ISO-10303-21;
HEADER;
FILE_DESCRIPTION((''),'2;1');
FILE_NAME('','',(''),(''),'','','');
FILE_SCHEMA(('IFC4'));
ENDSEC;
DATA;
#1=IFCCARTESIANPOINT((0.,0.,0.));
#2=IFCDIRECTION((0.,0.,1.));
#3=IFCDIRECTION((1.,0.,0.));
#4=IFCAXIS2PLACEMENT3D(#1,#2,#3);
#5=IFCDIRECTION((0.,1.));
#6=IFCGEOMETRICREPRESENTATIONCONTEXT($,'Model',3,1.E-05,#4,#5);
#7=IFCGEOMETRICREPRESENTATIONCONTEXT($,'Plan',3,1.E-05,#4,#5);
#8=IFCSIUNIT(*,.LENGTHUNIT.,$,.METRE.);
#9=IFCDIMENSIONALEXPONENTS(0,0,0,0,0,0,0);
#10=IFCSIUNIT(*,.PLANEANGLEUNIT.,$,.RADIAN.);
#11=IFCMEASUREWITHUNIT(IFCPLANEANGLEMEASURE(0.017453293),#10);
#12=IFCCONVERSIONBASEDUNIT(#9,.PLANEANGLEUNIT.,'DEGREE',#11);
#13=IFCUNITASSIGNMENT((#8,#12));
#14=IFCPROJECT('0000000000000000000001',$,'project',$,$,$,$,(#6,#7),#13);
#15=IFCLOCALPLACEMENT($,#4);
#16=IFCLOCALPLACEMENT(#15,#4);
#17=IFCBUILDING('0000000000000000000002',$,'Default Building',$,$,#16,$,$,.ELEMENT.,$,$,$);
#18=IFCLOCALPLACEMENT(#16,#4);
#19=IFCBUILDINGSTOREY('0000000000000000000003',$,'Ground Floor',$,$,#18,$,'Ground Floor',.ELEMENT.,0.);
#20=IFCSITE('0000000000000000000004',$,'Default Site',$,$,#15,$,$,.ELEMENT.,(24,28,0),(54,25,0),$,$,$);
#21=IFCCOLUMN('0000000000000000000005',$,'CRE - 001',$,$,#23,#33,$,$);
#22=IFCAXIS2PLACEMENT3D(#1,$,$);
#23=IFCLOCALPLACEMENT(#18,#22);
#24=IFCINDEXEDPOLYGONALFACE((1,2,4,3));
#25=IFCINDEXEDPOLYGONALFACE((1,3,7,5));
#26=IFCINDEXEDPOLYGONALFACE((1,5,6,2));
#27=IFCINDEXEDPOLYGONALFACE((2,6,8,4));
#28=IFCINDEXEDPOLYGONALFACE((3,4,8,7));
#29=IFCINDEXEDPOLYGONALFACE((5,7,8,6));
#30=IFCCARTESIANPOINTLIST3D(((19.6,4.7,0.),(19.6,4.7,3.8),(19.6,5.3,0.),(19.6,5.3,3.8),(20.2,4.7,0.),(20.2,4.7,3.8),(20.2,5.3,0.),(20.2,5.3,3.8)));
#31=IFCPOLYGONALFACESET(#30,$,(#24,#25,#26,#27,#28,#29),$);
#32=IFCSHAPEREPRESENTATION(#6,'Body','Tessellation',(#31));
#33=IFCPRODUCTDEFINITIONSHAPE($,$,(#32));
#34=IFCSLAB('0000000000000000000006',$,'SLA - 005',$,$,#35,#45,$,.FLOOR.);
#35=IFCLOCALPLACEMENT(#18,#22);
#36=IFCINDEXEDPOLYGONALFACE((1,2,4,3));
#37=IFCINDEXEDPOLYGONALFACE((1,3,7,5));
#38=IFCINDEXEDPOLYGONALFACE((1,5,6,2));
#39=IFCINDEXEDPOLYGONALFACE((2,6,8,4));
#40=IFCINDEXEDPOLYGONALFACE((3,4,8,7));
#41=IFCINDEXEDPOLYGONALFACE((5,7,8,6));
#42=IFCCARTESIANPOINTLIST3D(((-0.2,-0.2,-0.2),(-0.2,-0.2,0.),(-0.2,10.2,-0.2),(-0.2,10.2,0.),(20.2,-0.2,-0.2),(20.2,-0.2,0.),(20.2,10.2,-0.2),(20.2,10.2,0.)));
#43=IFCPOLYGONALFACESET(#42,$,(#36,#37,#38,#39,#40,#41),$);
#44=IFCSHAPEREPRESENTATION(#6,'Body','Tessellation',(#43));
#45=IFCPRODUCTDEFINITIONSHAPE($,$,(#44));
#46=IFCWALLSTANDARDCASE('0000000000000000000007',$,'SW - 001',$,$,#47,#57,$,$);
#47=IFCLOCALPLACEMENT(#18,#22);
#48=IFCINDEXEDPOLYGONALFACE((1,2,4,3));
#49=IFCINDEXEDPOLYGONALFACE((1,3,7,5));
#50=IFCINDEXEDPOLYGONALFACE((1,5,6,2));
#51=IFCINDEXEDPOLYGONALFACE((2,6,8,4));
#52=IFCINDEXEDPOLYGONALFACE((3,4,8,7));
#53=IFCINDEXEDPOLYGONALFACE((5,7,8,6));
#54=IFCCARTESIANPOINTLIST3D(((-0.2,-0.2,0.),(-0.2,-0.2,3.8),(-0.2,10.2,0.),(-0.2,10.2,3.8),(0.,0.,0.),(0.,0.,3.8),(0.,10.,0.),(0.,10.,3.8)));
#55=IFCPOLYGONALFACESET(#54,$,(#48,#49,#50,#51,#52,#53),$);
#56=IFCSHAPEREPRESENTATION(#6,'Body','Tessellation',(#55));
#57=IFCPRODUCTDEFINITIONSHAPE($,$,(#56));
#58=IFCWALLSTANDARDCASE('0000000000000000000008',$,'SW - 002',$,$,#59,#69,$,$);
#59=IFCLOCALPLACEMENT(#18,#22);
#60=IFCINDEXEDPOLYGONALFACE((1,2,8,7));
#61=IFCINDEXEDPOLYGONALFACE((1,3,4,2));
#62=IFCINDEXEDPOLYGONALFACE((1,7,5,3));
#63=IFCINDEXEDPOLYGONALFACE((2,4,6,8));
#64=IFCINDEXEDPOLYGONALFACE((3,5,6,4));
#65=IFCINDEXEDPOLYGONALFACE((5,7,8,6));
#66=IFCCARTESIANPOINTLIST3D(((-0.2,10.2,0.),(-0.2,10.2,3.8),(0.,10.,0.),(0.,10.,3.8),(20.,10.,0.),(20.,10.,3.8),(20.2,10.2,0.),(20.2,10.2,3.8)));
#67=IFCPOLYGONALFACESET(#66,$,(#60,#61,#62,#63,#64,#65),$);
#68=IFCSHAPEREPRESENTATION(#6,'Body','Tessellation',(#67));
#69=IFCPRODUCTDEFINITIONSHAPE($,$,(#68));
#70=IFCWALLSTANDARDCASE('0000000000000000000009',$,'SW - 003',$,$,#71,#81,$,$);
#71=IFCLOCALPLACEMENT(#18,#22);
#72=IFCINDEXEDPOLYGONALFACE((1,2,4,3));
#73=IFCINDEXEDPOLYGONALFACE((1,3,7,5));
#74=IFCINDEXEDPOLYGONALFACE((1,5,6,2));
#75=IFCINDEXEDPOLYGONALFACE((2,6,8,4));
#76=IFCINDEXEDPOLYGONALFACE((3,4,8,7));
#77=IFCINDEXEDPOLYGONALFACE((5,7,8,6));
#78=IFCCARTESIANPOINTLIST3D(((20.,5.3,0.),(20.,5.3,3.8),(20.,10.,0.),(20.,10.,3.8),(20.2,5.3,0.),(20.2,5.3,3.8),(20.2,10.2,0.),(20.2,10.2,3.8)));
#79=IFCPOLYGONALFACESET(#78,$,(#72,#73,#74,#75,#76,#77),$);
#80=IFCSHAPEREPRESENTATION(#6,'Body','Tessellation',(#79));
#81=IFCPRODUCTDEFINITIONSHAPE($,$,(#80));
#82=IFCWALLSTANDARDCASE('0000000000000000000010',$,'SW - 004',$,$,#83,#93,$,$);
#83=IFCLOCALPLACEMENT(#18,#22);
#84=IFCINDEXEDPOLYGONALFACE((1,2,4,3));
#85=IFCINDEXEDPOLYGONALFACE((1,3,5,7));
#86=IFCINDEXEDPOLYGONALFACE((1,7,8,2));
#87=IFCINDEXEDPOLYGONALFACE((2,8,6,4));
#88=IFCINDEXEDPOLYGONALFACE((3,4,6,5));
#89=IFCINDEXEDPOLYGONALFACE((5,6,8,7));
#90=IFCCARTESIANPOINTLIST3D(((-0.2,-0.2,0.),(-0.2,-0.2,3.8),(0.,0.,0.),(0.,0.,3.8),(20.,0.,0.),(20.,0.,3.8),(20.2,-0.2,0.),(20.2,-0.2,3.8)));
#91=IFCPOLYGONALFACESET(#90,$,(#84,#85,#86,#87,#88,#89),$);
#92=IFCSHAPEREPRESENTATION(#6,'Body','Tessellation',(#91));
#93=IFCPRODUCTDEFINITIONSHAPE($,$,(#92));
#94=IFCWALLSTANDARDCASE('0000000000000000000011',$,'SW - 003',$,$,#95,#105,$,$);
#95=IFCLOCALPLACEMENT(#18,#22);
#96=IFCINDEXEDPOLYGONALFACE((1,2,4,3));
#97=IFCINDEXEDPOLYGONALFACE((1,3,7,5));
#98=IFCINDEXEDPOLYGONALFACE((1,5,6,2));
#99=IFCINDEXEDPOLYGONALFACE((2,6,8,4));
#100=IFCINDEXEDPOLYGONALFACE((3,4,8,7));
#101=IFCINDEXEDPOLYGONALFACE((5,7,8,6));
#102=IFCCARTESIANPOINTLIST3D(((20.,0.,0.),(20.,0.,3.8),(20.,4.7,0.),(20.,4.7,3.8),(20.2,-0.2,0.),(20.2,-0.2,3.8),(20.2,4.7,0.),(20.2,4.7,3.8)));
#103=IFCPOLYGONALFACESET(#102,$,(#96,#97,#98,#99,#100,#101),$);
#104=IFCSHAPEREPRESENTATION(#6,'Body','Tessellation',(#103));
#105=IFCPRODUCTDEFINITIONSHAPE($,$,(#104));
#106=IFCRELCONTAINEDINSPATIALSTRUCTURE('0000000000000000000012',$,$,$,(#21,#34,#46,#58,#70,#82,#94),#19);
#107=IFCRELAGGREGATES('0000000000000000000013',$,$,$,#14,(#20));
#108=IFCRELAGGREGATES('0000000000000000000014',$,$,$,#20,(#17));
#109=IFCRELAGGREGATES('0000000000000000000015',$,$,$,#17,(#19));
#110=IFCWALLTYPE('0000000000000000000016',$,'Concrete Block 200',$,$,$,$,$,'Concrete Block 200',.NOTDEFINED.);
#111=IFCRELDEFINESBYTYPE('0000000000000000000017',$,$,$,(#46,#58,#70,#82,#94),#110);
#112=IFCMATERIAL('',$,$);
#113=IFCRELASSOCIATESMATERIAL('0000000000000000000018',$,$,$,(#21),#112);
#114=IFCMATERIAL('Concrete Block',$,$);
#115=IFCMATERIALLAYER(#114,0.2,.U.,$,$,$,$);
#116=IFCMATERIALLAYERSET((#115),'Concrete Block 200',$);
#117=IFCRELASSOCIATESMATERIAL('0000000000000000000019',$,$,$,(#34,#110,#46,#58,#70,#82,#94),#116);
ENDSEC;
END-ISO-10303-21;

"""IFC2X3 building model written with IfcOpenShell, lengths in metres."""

from ifc_helpers import new_model, entity, si_unit, converted_unit, direction, frame, origin_with_axes, origin_2d_with_axis, place, context, project, spatial, polyline, rectangle, outline, extrude, material, layer, layer_set, layer_usage, type_object, element, save


model = new_model("IFC2X3")

# Units and contexts
model_context = context("Model", 3, precision=1e-05, world=origin_with_axes(), true_north=direction((0.0, 1.0)))
plan_context = context("Plan", 3, precision=1e-05, world=origin_with_axes(), true_north=direction((0.0, 1.0)))
ifc_project = project(units=[si_unit("LENGTHUNIT", "METRE"), converted_unit("PLANEANGLEUNIT", "DEGREE", entity("IfcPlaneAngleMeasure", 0.017453293), si_unit("PLANEANGLEUNIT", "RADIAN"), dimensions=[0, 0, 0, 0, 0, 0, 0])], contexts=[model_context, plan_context])

# Site, building, storey
site_placement = place(None, origin_with_axes())
site = spatial("IfcSite", under=ifc_project, at=site_placement, Name="Default Site", CompositionType="ELEMENT", RefLatitude=(24, 28, 0), RefLongitude=(54, 25, 0))
building_placement = place(site_placement, origin_with_axes())
building = spatial("IfcBuilding", under=site, at=building_placement, Name="Default Building", CompositionType="ELEMENT")
storey_placement = place(building_placement, origin_with_axes())
storey = spatial("IfcBuildingStorey", under=building, at=storey_placement, Name="Ground Floor", LongName="Ground Floor", CompositionType="ELEMENT", Elevation=0.0)

# Column
ifc_material_1 = material(Name="")
column_placement = place(storey_placement, frame((19.9, 5.0, 0.0), z_axis=(0.0, 0.0, 1.0), x_axis=(1.0, 0.0, 0.0)))
element("IfcColumn", 1, at=column_placement, inside=storey, material=ifc_material_1, Name="CRE - 001", context=model_context, shape_type="SweptSolid", body=[
    extrude(rectangle(XDim=0.6, YDim=0.6, at=origin_2d_with_axis()), origin_with_axes(), (0.0, 0.0, 1.0), 3.8),
])

# Slab
ifc_material_2 = material(Name="Concrete Block")
ifc_layer = layer(ifc_material_2, 0.2, ventilated="UNKNOWN")
ifc_layer_set = layer_set([ifc_layer], Name="Concrete Block 200")
ifc_layer_usage_1 = layer_usage(ifc_layer_set, "AXIS3", "NEGATIVE", 0.2)
slab_placement = place(storey_placement, frame((-0.2, 10.2, -0.2), z_axis=(0.0, 0.0, 1.0), x_axis=(1.0, 0.0, 0.0)))
element("IfcSlab", 2, at=slab_placement, inside=storey, material=ifc_layer_usage_1, Name="SLA - 005", PredefinedType="FLOOR", context=model_context, shape_type="SweptSolid", body=[
    extrude(outline(polyline([(0.0, 0.0), (20.4, 0.0), (20.4, -10.4), (0.0, -10.4), (0.0, 0.0)])), origin_with_axes(), (0.0, 0.0, 1.0), 0.2),
])

# Walls
ifc_layer_usage_2 = layer_usage(ifc_layer_set, "AXIS2", "POSITIVE", 0.0)
wall_type = type_object("IfcWallType", Name="Concrete Block 200", ElementType="Concrete Block 200", PredefinedType="NOTDEFINED", material=ifc_layer_set)
wall_1_placement = place(storey_placement, frame((0.0, 0.0, 0.0), z_axis=(0.0, 0.0, 1.0), x_axis=(0.0, 1.0, 0.0)))
element("IfcWallStandardCase", 3, at=wall_1_placement, inside=storey, type_object=wall_type, material=ifc_layer_usage_2, Name="SW - 001", context=model_context, shape_type="SweptSolid", body=[
    extrude(outline(polyline([(0.0, 0.0), (10.0, 0.0), (10.2, 0.2), (-0.2, 0.2), (0.0, 0.0)])), origin_with_axes(), (0.0, 0.0, 1.0), 3.8),
])
ifc_layer_usage_3 = layer_usage(ifc_layer_set, "AXIS2", "POSITIVE", 0.0)
wall_2_placement = place(storey_placement, frame((0.0, 10.0, 0.0), z_axis=(0.0, 0.0, 1.0), x_axis=(1.0, 0.0, 0.0)))
element("IfcWallStandardCase", 4, at=wall_2_placement, inside=storey, type_object=wall_type, material=ifc_layer_usage_3, Name="SW - 002", context=model_context, shape_type="SweptSolid", body=[
    extrude(outline(polyline([(0.0, 0.0), (20.0, 0.0), (20.2, 0.2), (-0.2, 0.2), (0.0, 0.0)])), origin_with_axes(), (0.0, 0.0, 1.0), 3.8),
])
ifc_layer_usage_4 = layer_usage(ifc_layer_set, "AXIS2", "NEGATIVE", 0.0)
wall_3_placement = place(storey_placement, frame((20.2, 10.0, 0.0), z_axis=(0.0, 0.0, 1.0), x_axis=(0.0, -1.0, 0.0)))
element("IfcWallStandardCase", 5, at=wall_3_placement, inside=storey, type_object=wall_type, material=ifc_layer_usage_4, Name="SW - 003", context=model_context, shape_type="SweptSolid", body=[
    extrude(outline(polyline([(0.0, -0.2), (4.7, -0.2), (4.7, 0.0), (-0.2, 0.0), (0.0, -0.2)])), origin_with_axes(), (0.0, 0.0, 1.0), 3.8),
])
ifc_layer_usage_5 = layer_usage(ifc_layer_set, "AXIS2", "POSITIVE", 0.0)
wall_4_placement = place(storey_placement, frame((20.2, 0.0, 0.0), z_axis=(0.0, 0.0, 1.0), x_axis=(-1.0, 0.0, 0.0)))
element("IfcWallStandardCase", 6, at=wall_4_placement, inside=storey, type_object=wall_type, material=ifc_layer_usage_5, Name="SW - 004", context=model_context, shape_type="SweptSolid", body=[
    extrude(outline(polyline([(0.2, 0.0), (20.2, 0.0), (20.4, 0.2), (0.0, 0.2), (0.2, 0.0)])), origin_with_axes(), (0.0, 0.0, 1.0), 3.8),
])
ifc_layer_usage_6 = layer_usage(ifc_layer_set, "AXIS2", "NEGATIVE", 0.0)
wall_5_placement = place(storey_placement, frame((20.2, 4.7, 0.0), z_axis=(0.0, 0.0, 1.0), x_axis=(0.0, -1.0, 0.0)))
element("IfcWallStandardCase", 7, at=wall_5_placement, inside=storey, type_object=wall_type, material=ifc_layer_usage_6, Name="SW - 003", context=model_context, shape_type="SweptSolid", body=[
    extrude(outline(polyline([(0.0, -0.2), (4.7, -0.2), (4.9, 0.0), (0.0, 0.0), (0.0, -0.2)])), origin_with_axes(), (0.0, 0.0, 1.0), 3.8),
])

save(model, "model.ifc")
